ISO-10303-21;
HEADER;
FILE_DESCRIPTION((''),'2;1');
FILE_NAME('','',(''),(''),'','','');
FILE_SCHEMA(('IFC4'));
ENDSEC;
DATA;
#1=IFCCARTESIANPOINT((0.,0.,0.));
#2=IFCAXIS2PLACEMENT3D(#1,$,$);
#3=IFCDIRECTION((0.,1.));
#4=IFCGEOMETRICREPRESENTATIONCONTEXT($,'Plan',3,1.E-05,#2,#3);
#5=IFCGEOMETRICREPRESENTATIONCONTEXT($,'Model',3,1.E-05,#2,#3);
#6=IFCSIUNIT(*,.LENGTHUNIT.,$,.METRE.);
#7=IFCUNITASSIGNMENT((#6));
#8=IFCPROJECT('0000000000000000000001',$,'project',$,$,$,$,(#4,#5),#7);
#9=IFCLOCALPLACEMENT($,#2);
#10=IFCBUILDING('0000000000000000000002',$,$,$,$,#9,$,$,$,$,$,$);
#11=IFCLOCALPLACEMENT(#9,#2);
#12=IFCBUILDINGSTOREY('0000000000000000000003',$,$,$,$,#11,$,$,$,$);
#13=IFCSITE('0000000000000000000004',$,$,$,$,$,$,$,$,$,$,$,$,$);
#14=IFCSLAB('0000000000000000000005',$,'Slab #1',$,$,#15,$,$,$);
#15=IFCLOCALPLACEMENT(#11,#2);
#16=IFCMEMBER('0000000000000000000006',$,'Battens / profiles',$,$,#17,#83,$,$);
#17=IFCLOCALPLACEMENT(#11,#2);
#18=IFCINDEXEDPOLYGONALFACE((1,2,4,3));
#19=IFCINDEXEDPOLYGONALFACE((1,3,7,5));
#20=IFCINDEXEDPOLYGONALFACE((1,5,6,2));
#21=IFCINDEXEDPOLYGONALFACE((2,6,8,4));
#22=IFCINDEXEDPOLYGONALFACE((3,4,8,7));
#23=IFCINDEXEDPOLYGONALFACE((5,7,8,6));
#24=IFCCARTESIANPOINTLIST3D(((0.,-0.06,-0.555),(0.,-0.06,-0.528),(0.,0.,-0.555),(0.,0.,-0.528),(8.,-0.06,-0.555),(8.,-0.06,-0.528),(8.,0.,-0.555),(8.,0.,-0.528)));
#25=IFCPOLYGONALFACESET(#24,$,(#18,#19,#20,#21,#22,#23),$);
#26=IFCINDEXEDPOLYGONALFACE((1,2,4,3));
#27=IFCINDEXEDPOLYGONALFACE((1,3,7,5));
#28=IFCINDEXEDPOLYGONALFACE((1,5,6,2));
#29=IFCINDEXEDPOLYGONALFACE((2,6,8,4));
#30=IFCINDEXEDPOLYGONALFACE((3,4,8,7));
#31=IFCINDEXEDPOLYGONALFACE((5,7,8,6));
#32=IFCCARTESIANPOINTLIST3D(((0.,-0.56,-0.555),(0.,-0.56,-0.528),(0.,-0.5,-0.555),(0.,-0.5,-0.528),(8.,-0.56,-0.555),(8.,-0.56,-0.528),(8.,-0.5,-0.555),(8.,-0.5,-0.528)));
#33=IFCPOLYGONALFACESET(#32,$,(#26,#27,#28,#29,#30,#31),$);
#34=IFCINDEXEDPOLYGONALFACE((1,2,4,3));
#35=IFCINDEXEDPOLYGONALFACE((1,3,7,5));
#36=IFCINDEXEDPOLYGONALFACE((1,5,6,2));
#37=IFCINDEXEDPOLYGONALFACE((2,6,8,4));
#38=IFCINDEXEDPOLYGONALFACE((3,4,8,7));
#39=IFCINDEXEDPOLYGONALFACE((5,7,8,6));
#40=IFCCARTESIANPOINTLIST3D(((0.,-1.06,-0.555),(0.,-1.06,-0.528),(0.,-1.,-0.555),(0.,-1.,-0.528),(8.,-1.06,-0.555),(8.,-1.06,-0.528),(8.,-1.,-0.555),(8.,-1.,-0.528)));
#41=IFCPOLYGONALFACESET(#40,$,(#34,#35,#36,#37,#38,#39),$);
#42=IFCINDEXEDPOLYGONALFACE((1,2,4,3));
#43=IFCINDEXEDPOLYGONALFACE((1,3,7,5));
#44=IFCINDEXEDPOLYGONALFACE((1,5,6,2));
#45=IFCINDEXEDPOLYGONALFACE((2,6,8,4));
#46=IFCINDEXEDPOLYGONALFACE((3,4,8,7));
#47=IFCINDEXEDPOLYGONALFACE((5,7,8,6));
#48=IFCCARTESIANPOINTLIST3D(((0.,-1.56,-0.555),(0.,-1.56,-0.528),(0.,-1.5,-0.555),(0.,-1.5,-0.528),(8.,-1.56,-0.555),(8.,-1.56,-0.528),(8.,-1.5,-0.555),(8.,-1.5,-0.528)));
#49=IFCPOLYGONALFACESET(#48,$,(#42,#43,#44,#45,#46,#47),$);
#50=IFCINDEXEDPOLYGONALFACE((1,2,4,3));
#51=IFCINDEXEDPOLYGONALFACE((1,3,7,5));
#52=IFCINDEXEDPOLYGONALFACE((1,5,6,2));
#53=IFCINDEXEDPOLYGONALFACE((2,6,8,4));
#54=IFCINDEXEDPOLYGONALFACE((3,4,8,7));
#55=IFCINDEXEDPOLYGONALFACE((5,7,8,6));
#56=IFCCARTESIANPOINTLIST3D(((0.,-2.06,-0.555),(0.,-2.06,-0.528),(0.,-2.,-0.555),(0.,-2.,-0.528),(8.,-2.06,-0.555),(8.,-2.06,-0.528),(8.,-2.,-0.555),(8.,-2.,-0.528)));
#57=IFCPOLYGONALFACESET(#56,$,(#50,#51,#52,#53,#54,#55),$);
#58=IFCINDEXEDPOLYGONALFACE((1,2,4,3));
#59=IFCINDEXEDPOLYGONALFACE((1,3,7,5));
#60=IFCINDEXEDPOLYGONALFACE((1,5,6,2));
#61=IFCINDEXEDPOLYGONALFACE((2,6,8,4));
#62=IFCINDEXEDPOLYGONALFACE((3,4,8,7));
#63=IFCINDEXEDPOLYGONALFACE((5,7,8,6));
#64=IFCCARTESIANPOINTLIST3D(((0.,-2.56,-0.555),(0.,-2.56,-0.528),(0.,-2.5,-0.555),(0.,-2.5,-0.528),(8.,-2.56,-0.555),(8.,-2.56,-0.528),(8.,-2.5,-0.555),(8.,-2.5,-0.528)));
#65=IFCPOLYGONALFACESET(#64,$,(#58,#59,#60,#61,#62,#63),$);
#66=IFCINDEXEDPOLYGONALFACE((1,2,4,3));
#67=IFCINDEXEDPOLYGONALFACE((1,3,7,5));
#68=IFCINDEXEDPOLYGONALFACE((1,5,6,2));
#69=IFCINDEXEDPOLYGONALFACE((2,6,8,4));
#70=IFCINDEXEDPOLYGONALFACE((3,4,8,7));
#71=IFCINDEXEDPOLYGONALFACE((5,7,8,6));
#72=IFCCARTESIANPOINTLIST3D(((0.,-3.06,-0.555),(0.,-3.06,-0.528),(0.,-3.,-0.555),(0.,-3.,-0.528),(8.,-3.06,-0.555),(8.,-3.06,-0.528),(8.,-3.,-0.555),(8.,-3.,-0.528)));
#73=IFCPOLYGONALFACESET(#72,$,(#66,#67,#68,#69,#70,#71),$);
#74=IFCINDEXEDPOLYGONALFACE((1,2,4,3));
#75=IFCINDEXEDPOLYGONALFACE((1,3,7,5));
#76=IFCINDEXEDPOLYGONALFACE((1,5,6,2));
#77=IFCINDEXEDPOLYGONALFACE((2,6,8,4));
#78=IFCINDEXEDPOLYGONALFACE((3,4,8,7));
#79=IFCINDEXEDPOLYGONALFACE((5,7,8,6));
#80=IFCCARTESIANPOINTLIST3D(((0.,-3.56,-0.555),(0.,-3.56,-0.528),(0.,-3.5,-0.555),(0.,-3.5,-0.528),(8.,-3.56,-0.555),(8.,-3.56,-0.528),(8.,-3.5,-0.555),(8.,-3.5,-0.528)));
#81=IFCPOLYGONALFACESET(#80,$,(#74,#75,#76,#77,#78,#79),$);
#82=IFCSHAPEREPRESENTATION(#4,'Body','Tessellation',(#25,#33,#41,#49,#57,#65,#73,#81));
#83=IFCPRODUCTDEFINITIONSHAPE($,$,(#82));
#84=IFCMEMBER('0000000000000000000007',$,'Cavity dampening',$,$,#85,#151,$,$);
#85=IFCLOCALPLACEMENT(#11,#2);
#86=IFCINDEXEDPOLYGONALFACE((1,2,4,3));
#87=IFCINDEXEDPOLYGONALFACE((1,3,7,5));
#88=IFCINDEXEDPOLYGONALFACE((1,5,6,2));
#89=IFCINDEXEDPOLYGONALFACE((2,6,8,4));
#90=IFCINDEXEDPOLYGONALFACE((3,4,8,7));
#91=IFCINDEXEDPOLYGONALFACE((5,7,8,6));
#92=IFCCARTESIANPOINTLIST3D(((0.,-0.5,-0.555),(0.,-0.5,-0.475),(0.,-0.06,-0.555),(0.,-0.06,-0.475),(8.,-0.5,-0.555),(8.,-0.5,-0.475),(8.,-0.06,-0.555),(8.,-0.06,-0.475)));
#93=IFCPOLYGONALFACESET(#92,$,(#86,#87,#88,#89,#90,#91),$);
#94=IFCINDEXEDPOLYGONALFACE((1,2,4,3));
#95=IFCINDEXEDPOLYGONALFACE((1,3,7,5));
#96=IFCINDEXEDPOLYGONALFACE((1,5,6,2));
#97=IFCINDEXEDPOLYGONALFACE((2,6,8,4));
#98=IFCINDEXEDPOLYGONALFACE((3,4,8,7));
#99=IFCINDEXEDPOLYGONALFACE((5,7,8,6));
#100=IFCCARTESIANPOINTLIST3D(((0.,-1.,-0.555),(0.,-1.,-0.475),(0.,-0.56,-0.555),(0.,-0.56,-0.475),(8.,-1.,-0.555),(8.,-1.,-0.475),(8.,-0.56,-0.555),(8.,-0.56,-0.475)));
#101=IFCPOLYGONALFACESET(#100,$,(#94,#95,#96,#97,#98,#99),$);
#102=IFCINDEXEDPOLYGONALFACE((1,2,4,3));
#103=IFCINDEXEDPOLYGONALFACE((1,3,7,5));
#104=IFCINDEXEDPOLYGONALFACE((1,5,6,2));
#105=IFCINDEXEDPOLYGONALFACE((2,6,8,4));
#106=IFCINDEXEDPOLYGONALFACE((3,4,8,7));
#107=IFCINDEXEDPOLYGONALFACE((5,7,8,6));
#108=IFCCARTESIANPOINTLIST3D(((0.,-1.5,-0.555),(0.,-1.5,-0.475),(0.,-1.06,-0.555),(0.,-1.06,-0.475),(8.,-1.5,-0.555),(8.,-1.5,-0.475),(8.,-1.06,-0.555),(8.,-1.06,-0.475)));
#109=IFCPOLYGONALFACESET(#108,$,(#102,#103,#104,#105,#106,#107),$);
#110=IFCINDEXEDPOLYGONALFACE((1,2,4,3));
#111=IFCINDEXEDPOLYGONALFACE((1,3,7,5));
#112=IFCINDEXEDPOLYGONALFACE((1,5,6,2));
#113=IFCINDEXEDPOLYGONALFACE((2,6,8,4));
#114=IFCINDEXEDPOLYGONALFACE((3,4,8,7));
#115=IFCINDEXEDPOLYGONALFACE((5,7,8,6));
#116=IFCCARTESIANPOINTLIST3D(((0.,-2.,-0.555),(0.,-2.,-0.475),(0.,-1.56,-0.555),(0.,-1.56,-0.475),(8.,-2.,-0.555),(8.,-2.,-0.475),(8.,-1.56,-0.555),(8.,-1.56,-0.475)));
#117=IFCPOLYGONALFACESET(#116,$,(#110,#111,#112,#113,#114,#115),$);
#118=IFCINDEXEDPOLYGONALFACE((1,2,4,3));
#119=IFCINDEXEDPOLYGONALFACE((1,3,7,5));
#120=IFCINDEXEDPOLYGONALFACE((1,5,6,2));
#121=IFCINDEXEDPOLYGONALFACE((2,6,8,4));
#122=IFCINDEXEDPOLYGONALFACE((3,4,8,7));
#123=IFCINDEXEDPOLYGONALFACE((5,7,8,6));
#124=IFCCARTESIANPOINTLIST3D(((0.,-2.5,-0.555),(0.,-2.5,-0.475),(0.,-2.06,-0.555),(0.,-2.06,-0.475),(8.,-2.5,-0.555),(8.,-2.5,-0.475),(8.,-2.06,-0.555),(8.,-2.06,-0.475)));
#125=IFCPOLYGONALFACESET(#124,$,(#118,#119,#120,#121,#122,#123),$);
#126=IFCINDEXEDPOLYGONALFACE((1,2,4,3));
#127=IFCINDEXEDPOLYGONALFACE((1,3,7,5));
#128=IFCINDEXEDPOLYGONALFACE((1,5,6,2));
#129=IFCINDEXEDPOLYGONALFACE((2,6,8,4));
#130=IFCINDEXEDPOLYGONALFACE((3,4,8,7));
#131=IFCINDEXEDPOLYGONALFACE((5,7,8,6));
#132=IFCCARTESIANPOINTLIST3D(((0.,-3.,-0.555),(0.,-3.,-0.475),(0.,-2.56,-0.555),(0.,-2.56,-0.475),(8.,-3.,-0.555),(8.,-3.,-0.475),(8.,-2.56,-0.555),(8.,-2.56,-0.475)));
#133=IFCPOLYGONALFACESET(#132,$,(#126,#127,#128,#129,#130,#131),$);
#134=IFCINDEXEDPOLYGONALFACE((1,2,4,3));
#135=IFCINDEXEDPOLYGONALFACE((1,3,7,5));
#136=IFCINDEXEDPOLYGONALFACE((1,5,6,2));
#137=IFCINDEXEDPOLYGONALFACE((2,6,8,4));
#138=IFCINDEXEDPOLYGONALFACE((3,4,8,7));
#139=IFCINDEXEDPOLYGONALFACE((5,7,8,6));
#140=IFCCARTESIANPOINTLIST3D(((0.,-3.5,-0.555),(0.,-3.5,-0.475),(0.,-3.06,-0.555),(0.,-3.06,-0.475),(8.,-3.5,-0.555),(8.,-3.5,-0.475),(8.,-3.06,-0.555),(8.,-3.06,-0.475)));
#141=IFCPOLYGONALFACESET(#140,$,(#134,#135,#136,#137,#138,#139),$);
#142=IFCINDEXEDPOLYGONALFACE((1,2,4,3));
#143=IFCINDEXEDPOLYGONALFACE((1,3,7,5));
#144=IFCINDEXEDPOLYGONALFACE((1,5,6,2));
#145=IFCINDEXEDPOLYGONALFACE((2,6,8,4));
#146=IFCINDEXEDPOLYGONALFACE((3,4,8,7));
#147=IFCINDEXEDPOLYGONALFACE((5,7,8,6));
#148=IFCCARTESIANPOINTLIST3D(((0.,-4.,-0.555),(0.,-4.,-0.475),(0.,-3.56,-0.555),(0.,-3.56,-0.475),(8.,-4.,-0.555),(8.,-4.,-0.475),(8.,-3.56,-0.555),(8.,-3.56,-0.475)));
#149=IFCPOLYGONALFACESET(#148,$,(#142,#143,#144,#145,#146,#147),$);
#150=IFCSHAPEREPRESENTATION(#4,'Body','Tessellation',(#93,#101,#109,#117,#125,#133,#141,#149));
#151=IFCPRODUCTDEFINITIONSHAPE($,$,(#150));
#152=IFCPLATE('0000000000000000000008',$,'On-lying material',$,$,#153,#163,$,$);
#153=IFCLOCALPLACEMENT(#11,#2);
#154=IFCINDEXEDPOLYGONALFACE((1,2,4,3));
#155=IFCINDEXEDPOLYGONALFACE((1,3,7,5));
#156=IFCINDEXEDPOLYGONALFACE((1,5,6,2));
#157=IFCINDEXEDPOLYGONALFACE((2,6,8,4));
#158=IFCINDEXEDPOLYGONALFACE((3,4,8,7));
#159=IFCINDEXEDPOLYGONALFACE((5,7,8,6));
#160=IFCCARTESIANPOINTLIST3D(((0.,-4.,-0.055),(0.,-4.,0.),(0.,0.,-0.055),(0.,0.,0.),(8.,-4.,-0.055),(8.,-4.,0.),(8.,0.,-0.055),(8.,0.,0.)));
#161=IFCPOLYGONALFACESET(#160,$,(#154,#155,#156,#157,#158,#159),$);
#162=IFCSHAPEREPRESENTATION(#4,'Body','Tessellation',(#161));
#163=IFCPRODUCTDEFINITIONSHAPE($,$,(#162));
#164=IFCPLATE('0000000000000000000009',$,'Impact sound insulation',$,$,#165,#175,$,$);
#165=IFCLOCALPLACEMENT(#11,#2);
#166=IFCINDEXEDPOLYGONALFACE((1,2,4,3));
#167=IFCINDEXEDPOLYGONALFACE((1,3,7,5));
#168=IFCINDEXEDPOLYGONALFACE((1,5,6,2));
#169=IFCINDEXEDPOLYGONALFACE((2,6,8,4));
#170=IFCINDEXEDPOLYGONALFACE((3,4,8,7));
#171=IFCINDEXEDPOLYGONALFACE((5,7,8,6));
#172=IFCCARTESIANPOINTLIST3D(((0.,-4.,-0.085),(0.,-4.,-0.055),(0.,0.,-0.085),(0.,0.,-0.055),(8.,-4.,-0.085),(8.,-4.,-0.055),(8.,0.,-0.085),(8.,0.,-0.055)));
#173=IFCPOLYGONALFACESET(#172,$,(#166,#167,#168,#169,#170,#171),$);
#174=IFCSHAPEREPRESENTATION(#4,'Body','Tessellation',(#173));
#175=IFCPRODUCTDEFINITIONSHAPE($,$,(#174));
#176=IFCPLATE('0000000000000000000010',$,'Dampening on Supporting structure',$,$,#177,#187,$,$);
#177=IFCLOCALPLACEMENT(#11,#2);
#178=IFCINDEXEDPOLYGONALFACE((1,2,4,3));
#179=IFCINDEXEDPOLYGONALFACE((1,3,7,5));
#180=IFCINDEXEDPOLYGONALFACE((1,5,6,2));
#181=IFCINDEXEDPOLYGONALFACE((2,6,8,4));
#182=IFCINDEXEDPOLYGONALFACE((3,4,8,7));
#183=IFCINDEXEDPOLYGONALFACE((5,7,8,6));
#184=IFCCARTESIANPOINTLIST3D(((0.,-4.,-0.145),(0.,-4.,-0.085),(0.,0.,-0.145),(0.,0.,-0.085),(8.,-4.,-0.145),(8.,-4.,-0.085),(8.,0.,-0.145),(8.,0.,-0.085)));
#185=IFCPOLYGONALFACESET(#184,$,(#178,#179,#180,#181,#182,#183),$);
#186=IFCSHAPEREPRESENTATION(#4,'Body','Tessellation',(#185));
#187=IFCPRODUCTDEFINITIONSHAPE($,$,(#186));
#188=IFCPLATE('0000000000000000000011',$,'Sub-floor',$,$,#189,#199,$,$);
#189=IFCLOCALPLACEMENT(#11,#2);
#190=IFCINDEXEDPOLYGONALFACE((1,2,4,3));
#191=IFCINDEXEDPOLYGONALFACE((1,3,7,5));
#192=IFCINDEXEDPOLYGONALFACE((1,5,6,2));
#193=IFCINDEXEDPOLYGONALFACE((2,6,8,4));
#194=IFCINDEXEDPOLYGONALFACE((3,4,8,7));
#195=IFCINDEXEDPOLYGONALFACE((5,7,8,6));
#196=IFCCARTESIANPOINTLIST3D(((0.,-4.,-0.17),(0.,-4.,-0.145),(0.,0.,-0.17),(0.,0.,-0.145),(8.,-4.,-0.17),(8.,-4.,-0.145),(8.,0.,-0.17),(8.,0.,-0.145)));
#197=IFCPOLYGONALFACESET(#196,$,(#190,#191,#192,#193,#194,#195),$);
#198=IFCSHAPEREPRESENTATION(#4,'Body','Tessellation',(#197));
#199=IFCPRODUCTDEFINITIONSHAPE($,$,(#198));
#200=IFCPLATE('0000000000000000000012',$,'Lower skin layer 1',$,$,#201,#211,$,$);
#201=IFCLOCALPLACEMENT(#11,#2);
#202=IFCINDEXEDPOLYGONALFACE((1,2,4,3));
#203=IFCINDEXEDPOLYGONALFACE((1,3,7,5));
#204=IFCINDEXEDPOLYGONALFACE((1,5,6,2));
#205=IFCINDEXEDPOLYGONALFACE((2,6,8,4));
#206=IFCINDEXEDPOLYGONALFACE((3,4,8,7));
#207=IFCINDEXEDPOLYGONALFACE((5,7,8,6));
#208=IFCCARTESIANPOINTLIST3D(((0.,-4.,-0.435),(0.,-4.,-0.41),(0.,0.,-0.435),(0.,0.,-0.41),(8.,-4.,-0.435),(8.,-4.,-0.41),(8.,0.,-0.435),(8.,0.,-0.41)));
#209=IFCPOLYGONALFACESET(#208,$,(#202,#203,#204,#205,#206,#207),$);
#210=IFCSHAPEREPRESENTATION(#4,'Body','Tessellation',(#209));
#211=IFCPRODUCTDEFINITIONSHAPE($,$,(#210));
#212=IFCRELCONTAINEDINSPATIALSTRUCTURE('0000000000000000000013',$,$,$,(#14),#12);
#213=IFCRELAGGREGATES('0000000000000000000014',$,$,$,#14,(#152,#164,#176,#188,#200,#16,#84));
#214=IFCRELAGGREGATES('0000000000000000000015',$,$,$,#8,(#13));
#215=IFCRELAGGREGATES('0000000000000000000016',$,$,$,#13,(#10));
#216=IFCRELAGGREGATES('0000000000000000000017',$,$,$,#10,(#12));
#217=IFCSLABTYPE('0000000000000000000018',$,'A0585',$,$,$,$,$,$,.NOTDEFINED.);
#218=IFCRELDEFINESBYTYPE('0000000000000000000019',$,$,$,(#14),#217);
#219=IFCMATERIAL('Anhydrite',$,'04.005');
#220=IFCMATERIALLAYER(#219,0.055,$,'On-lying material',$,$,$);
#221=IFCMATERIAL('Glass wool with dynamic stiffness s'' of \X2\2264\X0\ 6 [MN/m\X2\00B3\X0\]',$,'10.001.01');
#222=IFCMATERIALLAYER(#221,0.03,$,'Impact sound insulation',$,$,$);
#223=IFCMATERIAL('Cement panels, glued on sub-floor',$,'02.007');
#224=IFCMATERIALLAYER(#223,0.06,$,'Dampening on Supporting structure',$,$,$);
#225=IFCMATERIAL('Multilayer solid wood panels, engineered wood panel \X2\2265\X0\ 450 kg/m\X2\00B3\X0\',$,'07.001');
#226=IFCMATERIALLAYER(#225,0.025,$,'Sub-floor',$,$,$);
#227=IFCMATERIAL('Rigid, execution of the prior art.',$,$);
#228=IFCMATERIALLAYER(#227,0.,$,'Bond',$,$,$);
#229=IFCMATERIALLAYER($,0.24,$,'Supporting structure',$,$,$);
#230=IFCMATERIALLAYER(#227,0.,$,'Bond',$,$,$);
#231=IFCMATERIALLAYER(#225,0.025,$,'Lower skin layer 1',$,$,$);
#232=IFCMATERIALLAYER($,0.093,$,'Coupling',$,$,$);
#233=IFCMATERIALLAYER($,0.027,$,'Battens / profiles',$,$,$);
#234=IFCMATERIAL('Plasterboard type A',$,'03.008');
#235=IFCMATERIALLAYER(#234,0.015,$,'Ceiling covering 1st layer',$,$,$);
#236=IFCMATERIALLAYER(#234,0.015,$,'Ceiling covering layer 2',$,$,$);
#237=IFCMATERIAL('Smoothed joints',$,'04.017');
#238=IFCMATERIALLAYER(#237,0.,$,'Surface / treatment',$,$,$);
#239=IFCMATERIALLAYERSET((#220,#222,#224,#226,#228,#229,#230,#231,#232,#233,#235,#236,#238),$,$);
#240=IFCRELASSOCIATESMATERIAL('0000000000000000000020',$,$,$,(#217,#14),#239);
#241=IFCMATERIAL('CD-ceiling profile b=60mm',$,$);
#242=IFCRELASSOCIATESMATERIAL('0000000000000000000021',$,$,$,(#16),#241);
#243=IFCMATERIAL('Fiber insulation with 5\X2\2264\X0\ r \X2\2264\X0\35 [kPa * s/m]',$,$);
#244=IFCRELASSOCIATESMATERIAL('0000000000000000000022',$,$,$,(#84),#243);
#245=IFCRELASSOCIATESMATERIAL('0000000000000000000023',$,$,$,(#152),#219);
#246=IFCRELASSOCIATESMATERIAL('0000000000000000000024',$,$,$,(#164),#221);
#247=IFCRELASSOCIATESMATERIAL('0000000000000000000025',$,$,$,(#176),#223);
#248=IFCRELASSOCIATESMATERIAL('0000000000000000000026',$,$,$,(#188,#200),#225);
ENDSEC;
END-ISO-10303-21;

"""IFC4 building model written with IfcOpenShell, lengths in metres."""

from ifc_helpers import new_model, si_unit, direction, frame, frame_2d, origin, origin_with_axes, place, context, project, spatial, rectangle, extrude, material, layer, layer_set, type_object, element, aggregate, save


model = new_model("IFC4")

# Units and contexts
plan_context = context("Plan", 3, precision=1e-05, world=origin(), true_north=direction((0.0, 1.0)))
model_context = context("Model", 3, precision=1e-05, world=origin(), true_north=direction((0.0, 1.0)))
ifc_project = project(units=[si_unit("LENGTHUNIT", "METRE")], contexts=[plan_context, model_context])

# Site, building, storey
site = spatial("IfcSite", under=ifc_project)
building_placement = place(None, origin())
building = spatial("IfcBuilding", under=site, at=building_placement)
storey_placement = place(building_placement, origin())
storey = spatial("IfcBuildingStorey", under=building, at=storey_placement)

# Slab, members, plates
ifc_material_1 = material(Name="Anhydrite", Category="04.005")
ifc_layer_1 = layer(ifc_material_1, 0.055, Name="On-lying material")
ifc_material_2 = material(Name="Glass wool with dynamic stiffness s' of ≤ 6 [MN/m³]", Category="10.001.01")
ifc_layer_2 = layer(ifc_material_2, 0.03, Name="Impact sound insulation")
ifc_material_3 = material(Name="Cement panels, glued on sub-floor", Category="02.007")
ifc_layer_3 = layer(ifc_material_3, 0.06, Name="Dampening on Supporting structure")
ifc_material_4 = material(Name="Multilayer solid wood panels, engineered wood panel ≥ 450 kg/m³", Category="07.001")
ifc_layer_4 = layer(ifc_material_4, 0.025, Name="Sub-floor")
ifc_material_5 = material(Name="Rigid, execution of the prior art.")
ifc_layer_5 = layer(ifc_material_5, 0.0, Name="Bond")
ifc_layer_6 = layer(None, 0.24, Name="Supporting structure")
ifc_layer_7 = layer(ifc_material_5, 0.0, Name="Bond")
ifc_layer_8 = layer(ifc_material_4, 0.025, Name="Lower skin layer 1")
ifc_layer_9 = layer(None, 0.093, Name="Coupling")
ifc_layer_10 = layer(None, 0.027, Name="Battens / profiles")
ifc_material_6 = material(Name="Plasterboard type A", Category="03.008")
ifc_layer_11 = layer(ifc_material_6, 0.015, Name="Ceiling covering 1st layer")
ifc_layer_12 = layer(ifc_material_6, 0.015, Name="Ceiling covering layer 2")
ifc_material_7 = material(Name="Smoothed joints", Category="04.017")
ifc_layer_13 = layer(ifc_material_7, 0.0, Name="Surface / treatment")
ifc_layer_set = layer_set([ifc_layer_1, ifc_layer_2, ifc_layer_3, ifc_layer_4, ifc_layer_5, ifc_layer_6, ifc_layer_7, ifc_layer_8, ifc_layer_9, ifc_layer_10, ifc_layer_11, ifc_layer_12, ifc_layer_13])
slab_type = type_object("IfcSlabType", Name="A0585", PredefinedType="NOTDEFINED", material=ifc_layer_set)
slab_placement = place(None, frame((0.0, 0.0, 0.0), z_axis=(0.0, 0.0, -1.0), x_axis=(1.0, 0.0, 0.0)))
slab = element("IfcSlab", 1, at=slab_placement, inside=storey, type_object=slab_type, material=ifc_layer_set, Name="Slab #1")
ifc_material_8 = material(Name="Fiber insulation with 5≤ r ≤35 [kPa * s/m]")
ifc_material_9 = material(Name="CD-ceiling profile b=60mm")
member_1_placement = place(slab_placement, origin())
member_1 = element("IfcMember", 2, at=member_1_placement, material=ifc_material_9, Name="Battens / profiles", context=plan_context, shape_type="SweptSolid", body=[
    extrude(rectangle(XDim=0.06, YDim=0.027, at=frame_2d((0.03, 0.0135), x_axis=(1.0, 0.0))), frame((0.0, 0.0, 0.528), z_axis=(1.0, 0.0, 0.0), x_axis=(0.0, 1.0, 0.0)), (0.0, 0.0, 1.0), 8.0),
    extrude(rectangle(XDim=0.06, YDim=0.027, at=frame_2d((0.03, 0.0135), x_axis=(1.0, 0.0))), frame((0.0, 0.5, 0.528), z_axis=(1.0, 0.0, 0.0), x_axis=(0.0, 1.0, 0.0)), (0.0, 0.0, 1.0), 8.0),
    extrude(rectangle(XDim=0.06, YDim=0.027, at=frame_2d((0.03, 0.0135), x_axis=(1.0, 0.0))), frame((0.0, 1.0, 0.528), z_axis=(1.0, 0.0, 0.0), x_axis=(0.0, 1.0, 0.0)), (0.0, 0.0, 1.0), 8.0),
    extrude(rectangle(XDim=0.06, YDim=0.027, at=frame_2d((0.03, 0.0135), x_axis=(1.0, 0.0))), frame((0.0, 1.5, 0.528), z_axis=(1.0, 0.0, 0.0), x_axis=(0.0, 1.0, 0.0)), (0.0, 0.0, 1.0), 8.0),
    extrude(rectangle(XDim=0.06, YDim=0.027, at=frame_2d((0.03, 0.0135), x_axis=(1.0, 0.0))), frame((0.0, 2.0, 0.528), z_axis=(1.0, 0.0, 0.0), x_axis=(0.0, 1.0, 0.0)), (0.0, 0.0, 1.0), 8.0),
    extrude(rectangle(XDim=0.06, YDim=0.027, at=frame_2d((0.03, 0.0135), x_axis=(1.0, 0.0))), frame((0.0, 2.5, 0.528), z_axis=(1.0, 0.0, 0.0), x_axis=(0.0, 1.0, 0.0)), (0.0, 0.0, 1.0), 8.0),
    extrude(rectangle(XDim=0.06, YDim=0.027, at=frame_2d((0.03, 0.0135), x_axis=(1.0, 0.0))), frame((0.0, 3.0, 0.528), z_axis=(1.0, 0.0, 0.0), x_axis=(0.0, 1.0, 0.0)), (0.0, 0.0, 1.0), 8.0),
    extrude(rectangle(XDim=0.06, YDim=0.027, at=frame_2d((0.03, 0.0135), x_axis=(1.0, 0.0))), frame((0.0, 3.5, 0.528), z_axis=(1.0, 0.0, 0.0), x_axis=(0.0, 1.0, 0.0)), (0.0, 0.0, 1.0), 8.0),
])
member_2_placement = place(slab_placement, origin())
member_2 = element("IfcMember", 3, at=member_2_placement, material=ifc_material_8, Name="Cavity dampening", context=plan_context, shape_type="SweptSolid", body=[
    extrude(rectangle(XDim=0.44, YDim=0.08, at=frame_2d((0.22, 0.04), x_axis=(1.0, 0.0))), frame((0.0, 0.06, 0.475), z_axis=(1.0, 0.0, 0.0), x_axis=(0.0, 1.0, 0.0)), (0.0, 0.0, 1.0), 8.0),
    extrude(rectangle(XDim=0.44, YDim=0.08, at=frame_2d((0.22, 0.04), x_axis=(1.0, 0.0))), frame((0.0, 0.56, 0.475), z_axis=(1.0, 0.0, 0.0), x_axis=(0.0, 1.0, 0.0)), (0.0, 0.0, 1.0), 8.0),
    extrude(rectangle(XDim=0.44, YDim=0.08, at=frame_2d((0.22, 0.04), x_axis=(1.0, 0.0))), frame((0.0, 1.06, 0.475), z_axis=(1.0, 0.0, 0.0), x_axis=(0.0, 1.0, 0.0)), (0.0, 0.0, 1.0), 8.0),
    extrude(rectangle(XDim=0.44, YDim=0.08, at=frame_2d((0.22, 0.04), x_axis=(1.0, 0.0))), frame((0.0, 1.56, 0.475), z_axis=(1.0, 0.0, 0.0), x_axis=(0.0, 1.0, 0.0)), (0.0, 0.0, 1.0), 8.0),
    extrude(rectangle(XDim=0.44, YDim=0.08, at=frame_2d((0.22, 0.04), x_axis=(1.0, 0.0))), frame((0.0, 2.06, 0.475), z_axis=(1.0, 0.0, 0.0), x_axis=(0.0, 1.0, 0.0)), (0.0, 0.0, 1.0), 8.0),
    extrude(rectangle(XDim=0.44, YDim=0.08, at=frame_2d((0.22, 0.04), x_axis=(1.0, 0.0))), frame((0.0, 2.56, 0.475), z_axis=(1.0, 0.0, 0.0), x_axis=(0.0, 1.0, 0.0)), (0.0, 0.0, 1.0), 8.0),
    extrude(rectangle(XDim=0.44, YDim=0.08, at=frame_2d((0.22, 0.04), x_axis=(1.0, 0.0))), frame((0.0, 3.06, 0.475), z_axis=(1.0, 0.0, 0.0), x_axis=(0.0, 1.0, 0.0)), (0.0, 0.0, 1.0), 8.0),
    extrude(rectangle(XDim=0.44, YDim=0.08, at=frame_2d((0.22, 0.04), x_axis=(1.0, 0.0))), frame((0.0, 3.56, 0.475), z_axis=(1.0, 0.0, 0.0), x_axis=(0.0, 1.0, 0.0)), (0.0, 0.0, 1.0), 8.0),
])
plate_1_placement = place(slab_placement, origin())
plate_1 = element("IfcPlate", 4, at=plate_1_placement, material=ifc_material_1, Name="On-lying material", context=plan_context, shape_type="SweptSolid", body=[
    extrude(rectangle(XDim=8.0, YDim=4.0, at=frame_2d((4.0, 2.0), x_axis=(1.0, 0.0))), origin_with_axes(), (0.0, 0.0, 1.0), 0.055),
])
plate_2_placement = place(slab_placement, origin())
plate_2 = element("IfcPlate", 5, at=plate_2_placement, material=ifc_material_2, Name="Impact sound insulation", context=plan_context, shape_type="SweptSolid", body=[
    extrude(rectangle(XDim=8.0, YDim=4.0, at=frame_2d((4.0, 2.0), x_axis=(1.0, 0.0))), frame((0.0, 0.0, 0.055), z_axis=(0.0, 0.0, 1.0), x_axis=(1.0, 0.0, 0.0)), (0.0, 0.0, 1.0), 0.03),
])
plate_3_placement = place(slab_placement, origin())
plate_3 = element("IfcPlate", 6, at=plate_3_placement, material=ifc_material_3, Name="Dampening on Supporting structure", context=plan_context, shape_type="SweptSolid", body=[
    extrude(rectangle(XDim=8.0, YDim=4.0, at=frame_2d((4.0, 2.0), x_axis=(1.0, 0.0))), frame((0.0, 0.0, 0.085), z_axis=(0.0, 0.0, 1.0), x_axis=(1.0, 0.0, 0.0)), (0.0, 0.0, 1.0), 0.06),
])
plate_4_placement = place(slab_placement, origin())
plate_4 = element("IfcPlate", 7, at=plate_4_placement, material=ifc_material_4, Name="Sub-floor", context=plan_context, shape_type="SweptSolid", body=[
    extrude(rectangle(XDim=8.0, YDim=4.0, at=frame_2d((4.0, 2.0), x_axis=(1.0, 0.0))), frame((0.0, 0.0, 0.145), z_axis=(0.0, 0.0, 1.0), x_axis=(1.0, 0.0, 0.0)), (0.0, 0.0, 1.0), 0.025),
])
plate_5_placement = place(slab_placement, origin())
plate_5 = element("IfcPlate", 8, at=plate_5_placement, material=ifc_material_4, Name="Lower skin layer 1", context=plan_context, shape_type="SweptSolid", body=[
    extrude(rectangle(XDim=8.0, YDim=4.0, at=frame_2d((4.0, 2.0), x_axis=(1.0, 0.0))), frame((0.0, 0.0, 0.41), z_axis=(0.0, 0.0, 1.0), x_axis=(1.0, 0.0, 0.0)), (0.0, 0.0, 1.0), 0.025),
])
aggregate(slab, [plate_1, plate_2, plate_3, plate_4, plate_5, member_1, member_2])

save(model, "model.ifc")
